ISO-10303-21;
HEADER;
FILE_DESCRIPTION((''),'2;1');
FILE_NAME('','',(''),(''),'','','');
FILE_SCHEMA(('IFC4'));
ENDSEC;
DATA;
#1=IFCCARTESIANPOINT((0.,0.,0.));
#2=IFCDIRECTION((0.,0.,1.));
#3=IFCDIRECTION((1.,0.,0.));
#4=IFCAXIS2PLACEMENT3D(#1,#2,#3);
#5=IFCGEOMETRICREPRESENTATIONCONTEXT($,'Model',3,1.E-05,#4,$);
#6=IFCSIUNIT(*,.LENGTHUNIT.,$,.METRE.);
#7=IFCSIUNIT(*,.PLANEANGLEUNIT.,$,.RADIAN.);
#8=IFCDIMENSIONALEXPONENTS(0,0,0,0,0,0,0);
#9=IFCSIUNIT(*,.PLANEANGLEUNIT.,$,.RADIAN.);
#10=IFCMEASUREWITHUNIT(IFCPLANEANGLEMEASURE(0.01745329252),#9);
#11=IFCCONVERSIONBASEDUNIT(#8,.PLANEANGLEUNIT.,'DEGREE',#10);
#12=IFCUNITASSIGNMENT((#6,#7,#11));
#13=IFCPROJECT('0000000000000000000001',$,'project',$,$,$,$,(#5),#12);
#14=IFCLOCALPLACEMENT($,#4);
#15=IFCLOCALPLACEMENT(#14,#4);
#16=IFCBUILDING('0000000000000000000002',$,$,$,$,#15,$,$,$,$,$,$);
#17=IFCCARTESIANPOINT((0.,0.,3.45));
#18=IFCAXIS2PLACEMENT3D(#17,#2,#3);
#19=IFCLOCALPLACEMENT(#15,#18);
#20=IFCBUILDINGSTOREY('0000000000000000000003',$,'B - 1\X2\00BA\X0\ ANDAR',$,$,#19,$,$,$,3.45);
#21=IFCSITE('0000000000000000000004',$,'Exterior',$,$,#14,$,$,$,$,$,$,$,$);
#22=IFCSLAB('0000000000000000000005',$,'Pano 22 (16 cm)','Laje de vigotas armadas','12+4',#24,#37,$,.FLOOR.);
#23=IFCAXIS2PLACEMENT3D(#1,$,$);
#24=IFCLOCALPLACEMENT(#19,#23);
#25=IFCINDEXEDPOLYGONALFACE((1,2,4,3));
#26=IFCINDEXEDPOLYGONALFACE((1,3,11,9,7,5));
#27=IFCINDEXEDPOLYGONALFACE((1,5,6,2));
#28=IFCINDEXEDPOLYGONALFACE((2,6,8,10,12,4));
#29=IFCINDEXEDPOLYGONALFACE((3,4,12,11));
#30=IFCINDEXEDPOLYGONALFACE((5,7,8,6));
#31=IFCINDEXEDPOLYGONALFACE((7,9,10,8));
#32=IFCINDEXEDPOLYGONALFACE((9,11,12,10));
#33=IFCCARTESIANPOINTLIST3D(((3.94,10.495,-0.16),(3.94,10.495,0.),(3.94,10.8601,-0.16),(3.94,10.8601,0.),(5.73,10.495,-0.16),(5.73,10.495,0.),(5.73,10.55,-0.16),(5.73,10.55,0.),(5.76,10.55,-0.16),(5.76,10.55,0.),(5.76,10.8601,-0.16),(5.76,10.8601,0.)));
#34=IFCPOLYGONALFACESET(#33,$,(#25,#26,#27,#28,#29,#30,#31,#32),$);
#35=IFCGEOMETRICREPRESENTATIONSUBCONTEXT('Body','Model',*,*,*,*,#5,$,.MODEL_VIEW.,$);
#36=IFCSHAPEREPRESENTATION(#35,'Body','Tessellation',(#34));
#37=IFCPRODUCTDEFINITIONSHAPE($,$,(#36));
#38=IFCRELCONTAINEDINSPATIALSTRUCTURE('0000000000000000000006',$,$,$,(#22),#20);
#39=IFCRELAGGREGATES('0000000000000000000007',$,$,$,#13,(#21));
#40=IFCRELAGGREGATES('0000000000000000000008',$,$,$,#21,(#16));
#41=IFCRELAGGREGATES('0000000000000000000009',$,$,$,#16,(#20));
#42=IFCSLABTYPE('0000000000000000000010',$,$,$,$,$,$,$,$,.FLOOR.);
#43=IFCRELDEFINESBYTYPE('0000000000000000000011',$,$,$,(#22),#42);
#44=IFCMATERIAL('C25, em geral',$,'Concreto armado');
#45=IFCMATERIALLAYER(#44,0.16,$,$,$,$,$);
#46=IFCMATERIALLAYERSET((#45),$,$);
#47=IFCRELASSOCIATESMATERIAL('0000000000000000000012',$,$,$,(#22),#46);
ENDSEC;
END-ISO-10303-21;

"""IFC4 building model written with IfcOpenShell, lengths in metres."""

from ifc_helpers import new_model, entity, si_unit, converted_unit, frame, origin_with_axes, place, context, subcontext, project, spatial, polyline, outline, extrude, material, layer, layer_set, layer_usage, type_object, element, save


model = new_model("IFC4")

# Units and contexts
model_context = context("Model", 3, precision=1e-05, world=origin_with_axes())
body_context = subcontext(model_context, "Body", "Model", "MODEL_VIEW")
ifc_project = project(units=[si_unit("LENGTHUNIT", "METRE"), si_unit("PLANEANGLEUNIT", "RADIAN"), converted_unit("PLANEANGLEUNIT", "DEGREE", entity("IfcPlaneAngleMeasure", 0.01745329252), si_unit("PLANEANGLEUNIT", "RADIAN"), dimensions=[0, 0, 0, 0, 0, 0, 0])], contexts=[model_context])

# Shared definitions
site_placement = place(None, origin_with_axes())
building_placement = place(site_placement, origin_with_axes())
storey_placement = place(building_placement, frame((0.0, 0.0, 3.45), z_axis=(0.0, 0.0, 1.0), x_axis=(1.0, 0.0, 0.0)))

# Shared definitions
ifc_material_1 = material(Name="C25, em geral", Category="Concreto armado")

# Site, building, storey
site = spatial("IfcSite", under=ifc_project, at=site_placement, Name="Exterior")
building = spatial("IfcBuilding", under=site, at=building_placement)
storey = spatial("IfcBuildingStorey", under=building, at=storey_placement, Name="B - 1º ANDAR", Elevation=3.45)

# Slab
slab_type = type_object("IfcSlabType", PredefinedType="FLOOR")
ifc_layer_1 = layer(ifc_material_1, 0.16)
ifc_layer_set_1 = layer_set([ifc_layer_1])
ifc_layer_usage_1 = layer_usage(ifc_layer_set_1, "AXIS3", "POSITIVE", 0.0)
slab_1_placement = place(storey_placement, frame((0.0, 0.0, -0.16), z_axis=(0.0, 0.0, 1.0), x_axis=(1.0, 0.0, 0.0)))
element("IfcSlab", 1, at=slab_1_placement, inside=storey, type_object=slab_type, material=ifc_layer_usage_1, Name="Pano 22 (16 cm)", Description="Laje de vigotas armadas", ObjectType="12+4", PredefinedType="FLOOR", context=body_context, shape_type="SweptSolid", body=[
    extrude(outline(polyline([(3.94, 10.8601), (3.94, 10.495), (5.73, 10.495), (5.73, 10.55), (5.76, 10.55), (5.76, 10.8601), (3.94, 10.8601)])), origin_with_axes(), (0.0, 0.0, 1.0), 0.16),
])

save(model, "model.ifc")
